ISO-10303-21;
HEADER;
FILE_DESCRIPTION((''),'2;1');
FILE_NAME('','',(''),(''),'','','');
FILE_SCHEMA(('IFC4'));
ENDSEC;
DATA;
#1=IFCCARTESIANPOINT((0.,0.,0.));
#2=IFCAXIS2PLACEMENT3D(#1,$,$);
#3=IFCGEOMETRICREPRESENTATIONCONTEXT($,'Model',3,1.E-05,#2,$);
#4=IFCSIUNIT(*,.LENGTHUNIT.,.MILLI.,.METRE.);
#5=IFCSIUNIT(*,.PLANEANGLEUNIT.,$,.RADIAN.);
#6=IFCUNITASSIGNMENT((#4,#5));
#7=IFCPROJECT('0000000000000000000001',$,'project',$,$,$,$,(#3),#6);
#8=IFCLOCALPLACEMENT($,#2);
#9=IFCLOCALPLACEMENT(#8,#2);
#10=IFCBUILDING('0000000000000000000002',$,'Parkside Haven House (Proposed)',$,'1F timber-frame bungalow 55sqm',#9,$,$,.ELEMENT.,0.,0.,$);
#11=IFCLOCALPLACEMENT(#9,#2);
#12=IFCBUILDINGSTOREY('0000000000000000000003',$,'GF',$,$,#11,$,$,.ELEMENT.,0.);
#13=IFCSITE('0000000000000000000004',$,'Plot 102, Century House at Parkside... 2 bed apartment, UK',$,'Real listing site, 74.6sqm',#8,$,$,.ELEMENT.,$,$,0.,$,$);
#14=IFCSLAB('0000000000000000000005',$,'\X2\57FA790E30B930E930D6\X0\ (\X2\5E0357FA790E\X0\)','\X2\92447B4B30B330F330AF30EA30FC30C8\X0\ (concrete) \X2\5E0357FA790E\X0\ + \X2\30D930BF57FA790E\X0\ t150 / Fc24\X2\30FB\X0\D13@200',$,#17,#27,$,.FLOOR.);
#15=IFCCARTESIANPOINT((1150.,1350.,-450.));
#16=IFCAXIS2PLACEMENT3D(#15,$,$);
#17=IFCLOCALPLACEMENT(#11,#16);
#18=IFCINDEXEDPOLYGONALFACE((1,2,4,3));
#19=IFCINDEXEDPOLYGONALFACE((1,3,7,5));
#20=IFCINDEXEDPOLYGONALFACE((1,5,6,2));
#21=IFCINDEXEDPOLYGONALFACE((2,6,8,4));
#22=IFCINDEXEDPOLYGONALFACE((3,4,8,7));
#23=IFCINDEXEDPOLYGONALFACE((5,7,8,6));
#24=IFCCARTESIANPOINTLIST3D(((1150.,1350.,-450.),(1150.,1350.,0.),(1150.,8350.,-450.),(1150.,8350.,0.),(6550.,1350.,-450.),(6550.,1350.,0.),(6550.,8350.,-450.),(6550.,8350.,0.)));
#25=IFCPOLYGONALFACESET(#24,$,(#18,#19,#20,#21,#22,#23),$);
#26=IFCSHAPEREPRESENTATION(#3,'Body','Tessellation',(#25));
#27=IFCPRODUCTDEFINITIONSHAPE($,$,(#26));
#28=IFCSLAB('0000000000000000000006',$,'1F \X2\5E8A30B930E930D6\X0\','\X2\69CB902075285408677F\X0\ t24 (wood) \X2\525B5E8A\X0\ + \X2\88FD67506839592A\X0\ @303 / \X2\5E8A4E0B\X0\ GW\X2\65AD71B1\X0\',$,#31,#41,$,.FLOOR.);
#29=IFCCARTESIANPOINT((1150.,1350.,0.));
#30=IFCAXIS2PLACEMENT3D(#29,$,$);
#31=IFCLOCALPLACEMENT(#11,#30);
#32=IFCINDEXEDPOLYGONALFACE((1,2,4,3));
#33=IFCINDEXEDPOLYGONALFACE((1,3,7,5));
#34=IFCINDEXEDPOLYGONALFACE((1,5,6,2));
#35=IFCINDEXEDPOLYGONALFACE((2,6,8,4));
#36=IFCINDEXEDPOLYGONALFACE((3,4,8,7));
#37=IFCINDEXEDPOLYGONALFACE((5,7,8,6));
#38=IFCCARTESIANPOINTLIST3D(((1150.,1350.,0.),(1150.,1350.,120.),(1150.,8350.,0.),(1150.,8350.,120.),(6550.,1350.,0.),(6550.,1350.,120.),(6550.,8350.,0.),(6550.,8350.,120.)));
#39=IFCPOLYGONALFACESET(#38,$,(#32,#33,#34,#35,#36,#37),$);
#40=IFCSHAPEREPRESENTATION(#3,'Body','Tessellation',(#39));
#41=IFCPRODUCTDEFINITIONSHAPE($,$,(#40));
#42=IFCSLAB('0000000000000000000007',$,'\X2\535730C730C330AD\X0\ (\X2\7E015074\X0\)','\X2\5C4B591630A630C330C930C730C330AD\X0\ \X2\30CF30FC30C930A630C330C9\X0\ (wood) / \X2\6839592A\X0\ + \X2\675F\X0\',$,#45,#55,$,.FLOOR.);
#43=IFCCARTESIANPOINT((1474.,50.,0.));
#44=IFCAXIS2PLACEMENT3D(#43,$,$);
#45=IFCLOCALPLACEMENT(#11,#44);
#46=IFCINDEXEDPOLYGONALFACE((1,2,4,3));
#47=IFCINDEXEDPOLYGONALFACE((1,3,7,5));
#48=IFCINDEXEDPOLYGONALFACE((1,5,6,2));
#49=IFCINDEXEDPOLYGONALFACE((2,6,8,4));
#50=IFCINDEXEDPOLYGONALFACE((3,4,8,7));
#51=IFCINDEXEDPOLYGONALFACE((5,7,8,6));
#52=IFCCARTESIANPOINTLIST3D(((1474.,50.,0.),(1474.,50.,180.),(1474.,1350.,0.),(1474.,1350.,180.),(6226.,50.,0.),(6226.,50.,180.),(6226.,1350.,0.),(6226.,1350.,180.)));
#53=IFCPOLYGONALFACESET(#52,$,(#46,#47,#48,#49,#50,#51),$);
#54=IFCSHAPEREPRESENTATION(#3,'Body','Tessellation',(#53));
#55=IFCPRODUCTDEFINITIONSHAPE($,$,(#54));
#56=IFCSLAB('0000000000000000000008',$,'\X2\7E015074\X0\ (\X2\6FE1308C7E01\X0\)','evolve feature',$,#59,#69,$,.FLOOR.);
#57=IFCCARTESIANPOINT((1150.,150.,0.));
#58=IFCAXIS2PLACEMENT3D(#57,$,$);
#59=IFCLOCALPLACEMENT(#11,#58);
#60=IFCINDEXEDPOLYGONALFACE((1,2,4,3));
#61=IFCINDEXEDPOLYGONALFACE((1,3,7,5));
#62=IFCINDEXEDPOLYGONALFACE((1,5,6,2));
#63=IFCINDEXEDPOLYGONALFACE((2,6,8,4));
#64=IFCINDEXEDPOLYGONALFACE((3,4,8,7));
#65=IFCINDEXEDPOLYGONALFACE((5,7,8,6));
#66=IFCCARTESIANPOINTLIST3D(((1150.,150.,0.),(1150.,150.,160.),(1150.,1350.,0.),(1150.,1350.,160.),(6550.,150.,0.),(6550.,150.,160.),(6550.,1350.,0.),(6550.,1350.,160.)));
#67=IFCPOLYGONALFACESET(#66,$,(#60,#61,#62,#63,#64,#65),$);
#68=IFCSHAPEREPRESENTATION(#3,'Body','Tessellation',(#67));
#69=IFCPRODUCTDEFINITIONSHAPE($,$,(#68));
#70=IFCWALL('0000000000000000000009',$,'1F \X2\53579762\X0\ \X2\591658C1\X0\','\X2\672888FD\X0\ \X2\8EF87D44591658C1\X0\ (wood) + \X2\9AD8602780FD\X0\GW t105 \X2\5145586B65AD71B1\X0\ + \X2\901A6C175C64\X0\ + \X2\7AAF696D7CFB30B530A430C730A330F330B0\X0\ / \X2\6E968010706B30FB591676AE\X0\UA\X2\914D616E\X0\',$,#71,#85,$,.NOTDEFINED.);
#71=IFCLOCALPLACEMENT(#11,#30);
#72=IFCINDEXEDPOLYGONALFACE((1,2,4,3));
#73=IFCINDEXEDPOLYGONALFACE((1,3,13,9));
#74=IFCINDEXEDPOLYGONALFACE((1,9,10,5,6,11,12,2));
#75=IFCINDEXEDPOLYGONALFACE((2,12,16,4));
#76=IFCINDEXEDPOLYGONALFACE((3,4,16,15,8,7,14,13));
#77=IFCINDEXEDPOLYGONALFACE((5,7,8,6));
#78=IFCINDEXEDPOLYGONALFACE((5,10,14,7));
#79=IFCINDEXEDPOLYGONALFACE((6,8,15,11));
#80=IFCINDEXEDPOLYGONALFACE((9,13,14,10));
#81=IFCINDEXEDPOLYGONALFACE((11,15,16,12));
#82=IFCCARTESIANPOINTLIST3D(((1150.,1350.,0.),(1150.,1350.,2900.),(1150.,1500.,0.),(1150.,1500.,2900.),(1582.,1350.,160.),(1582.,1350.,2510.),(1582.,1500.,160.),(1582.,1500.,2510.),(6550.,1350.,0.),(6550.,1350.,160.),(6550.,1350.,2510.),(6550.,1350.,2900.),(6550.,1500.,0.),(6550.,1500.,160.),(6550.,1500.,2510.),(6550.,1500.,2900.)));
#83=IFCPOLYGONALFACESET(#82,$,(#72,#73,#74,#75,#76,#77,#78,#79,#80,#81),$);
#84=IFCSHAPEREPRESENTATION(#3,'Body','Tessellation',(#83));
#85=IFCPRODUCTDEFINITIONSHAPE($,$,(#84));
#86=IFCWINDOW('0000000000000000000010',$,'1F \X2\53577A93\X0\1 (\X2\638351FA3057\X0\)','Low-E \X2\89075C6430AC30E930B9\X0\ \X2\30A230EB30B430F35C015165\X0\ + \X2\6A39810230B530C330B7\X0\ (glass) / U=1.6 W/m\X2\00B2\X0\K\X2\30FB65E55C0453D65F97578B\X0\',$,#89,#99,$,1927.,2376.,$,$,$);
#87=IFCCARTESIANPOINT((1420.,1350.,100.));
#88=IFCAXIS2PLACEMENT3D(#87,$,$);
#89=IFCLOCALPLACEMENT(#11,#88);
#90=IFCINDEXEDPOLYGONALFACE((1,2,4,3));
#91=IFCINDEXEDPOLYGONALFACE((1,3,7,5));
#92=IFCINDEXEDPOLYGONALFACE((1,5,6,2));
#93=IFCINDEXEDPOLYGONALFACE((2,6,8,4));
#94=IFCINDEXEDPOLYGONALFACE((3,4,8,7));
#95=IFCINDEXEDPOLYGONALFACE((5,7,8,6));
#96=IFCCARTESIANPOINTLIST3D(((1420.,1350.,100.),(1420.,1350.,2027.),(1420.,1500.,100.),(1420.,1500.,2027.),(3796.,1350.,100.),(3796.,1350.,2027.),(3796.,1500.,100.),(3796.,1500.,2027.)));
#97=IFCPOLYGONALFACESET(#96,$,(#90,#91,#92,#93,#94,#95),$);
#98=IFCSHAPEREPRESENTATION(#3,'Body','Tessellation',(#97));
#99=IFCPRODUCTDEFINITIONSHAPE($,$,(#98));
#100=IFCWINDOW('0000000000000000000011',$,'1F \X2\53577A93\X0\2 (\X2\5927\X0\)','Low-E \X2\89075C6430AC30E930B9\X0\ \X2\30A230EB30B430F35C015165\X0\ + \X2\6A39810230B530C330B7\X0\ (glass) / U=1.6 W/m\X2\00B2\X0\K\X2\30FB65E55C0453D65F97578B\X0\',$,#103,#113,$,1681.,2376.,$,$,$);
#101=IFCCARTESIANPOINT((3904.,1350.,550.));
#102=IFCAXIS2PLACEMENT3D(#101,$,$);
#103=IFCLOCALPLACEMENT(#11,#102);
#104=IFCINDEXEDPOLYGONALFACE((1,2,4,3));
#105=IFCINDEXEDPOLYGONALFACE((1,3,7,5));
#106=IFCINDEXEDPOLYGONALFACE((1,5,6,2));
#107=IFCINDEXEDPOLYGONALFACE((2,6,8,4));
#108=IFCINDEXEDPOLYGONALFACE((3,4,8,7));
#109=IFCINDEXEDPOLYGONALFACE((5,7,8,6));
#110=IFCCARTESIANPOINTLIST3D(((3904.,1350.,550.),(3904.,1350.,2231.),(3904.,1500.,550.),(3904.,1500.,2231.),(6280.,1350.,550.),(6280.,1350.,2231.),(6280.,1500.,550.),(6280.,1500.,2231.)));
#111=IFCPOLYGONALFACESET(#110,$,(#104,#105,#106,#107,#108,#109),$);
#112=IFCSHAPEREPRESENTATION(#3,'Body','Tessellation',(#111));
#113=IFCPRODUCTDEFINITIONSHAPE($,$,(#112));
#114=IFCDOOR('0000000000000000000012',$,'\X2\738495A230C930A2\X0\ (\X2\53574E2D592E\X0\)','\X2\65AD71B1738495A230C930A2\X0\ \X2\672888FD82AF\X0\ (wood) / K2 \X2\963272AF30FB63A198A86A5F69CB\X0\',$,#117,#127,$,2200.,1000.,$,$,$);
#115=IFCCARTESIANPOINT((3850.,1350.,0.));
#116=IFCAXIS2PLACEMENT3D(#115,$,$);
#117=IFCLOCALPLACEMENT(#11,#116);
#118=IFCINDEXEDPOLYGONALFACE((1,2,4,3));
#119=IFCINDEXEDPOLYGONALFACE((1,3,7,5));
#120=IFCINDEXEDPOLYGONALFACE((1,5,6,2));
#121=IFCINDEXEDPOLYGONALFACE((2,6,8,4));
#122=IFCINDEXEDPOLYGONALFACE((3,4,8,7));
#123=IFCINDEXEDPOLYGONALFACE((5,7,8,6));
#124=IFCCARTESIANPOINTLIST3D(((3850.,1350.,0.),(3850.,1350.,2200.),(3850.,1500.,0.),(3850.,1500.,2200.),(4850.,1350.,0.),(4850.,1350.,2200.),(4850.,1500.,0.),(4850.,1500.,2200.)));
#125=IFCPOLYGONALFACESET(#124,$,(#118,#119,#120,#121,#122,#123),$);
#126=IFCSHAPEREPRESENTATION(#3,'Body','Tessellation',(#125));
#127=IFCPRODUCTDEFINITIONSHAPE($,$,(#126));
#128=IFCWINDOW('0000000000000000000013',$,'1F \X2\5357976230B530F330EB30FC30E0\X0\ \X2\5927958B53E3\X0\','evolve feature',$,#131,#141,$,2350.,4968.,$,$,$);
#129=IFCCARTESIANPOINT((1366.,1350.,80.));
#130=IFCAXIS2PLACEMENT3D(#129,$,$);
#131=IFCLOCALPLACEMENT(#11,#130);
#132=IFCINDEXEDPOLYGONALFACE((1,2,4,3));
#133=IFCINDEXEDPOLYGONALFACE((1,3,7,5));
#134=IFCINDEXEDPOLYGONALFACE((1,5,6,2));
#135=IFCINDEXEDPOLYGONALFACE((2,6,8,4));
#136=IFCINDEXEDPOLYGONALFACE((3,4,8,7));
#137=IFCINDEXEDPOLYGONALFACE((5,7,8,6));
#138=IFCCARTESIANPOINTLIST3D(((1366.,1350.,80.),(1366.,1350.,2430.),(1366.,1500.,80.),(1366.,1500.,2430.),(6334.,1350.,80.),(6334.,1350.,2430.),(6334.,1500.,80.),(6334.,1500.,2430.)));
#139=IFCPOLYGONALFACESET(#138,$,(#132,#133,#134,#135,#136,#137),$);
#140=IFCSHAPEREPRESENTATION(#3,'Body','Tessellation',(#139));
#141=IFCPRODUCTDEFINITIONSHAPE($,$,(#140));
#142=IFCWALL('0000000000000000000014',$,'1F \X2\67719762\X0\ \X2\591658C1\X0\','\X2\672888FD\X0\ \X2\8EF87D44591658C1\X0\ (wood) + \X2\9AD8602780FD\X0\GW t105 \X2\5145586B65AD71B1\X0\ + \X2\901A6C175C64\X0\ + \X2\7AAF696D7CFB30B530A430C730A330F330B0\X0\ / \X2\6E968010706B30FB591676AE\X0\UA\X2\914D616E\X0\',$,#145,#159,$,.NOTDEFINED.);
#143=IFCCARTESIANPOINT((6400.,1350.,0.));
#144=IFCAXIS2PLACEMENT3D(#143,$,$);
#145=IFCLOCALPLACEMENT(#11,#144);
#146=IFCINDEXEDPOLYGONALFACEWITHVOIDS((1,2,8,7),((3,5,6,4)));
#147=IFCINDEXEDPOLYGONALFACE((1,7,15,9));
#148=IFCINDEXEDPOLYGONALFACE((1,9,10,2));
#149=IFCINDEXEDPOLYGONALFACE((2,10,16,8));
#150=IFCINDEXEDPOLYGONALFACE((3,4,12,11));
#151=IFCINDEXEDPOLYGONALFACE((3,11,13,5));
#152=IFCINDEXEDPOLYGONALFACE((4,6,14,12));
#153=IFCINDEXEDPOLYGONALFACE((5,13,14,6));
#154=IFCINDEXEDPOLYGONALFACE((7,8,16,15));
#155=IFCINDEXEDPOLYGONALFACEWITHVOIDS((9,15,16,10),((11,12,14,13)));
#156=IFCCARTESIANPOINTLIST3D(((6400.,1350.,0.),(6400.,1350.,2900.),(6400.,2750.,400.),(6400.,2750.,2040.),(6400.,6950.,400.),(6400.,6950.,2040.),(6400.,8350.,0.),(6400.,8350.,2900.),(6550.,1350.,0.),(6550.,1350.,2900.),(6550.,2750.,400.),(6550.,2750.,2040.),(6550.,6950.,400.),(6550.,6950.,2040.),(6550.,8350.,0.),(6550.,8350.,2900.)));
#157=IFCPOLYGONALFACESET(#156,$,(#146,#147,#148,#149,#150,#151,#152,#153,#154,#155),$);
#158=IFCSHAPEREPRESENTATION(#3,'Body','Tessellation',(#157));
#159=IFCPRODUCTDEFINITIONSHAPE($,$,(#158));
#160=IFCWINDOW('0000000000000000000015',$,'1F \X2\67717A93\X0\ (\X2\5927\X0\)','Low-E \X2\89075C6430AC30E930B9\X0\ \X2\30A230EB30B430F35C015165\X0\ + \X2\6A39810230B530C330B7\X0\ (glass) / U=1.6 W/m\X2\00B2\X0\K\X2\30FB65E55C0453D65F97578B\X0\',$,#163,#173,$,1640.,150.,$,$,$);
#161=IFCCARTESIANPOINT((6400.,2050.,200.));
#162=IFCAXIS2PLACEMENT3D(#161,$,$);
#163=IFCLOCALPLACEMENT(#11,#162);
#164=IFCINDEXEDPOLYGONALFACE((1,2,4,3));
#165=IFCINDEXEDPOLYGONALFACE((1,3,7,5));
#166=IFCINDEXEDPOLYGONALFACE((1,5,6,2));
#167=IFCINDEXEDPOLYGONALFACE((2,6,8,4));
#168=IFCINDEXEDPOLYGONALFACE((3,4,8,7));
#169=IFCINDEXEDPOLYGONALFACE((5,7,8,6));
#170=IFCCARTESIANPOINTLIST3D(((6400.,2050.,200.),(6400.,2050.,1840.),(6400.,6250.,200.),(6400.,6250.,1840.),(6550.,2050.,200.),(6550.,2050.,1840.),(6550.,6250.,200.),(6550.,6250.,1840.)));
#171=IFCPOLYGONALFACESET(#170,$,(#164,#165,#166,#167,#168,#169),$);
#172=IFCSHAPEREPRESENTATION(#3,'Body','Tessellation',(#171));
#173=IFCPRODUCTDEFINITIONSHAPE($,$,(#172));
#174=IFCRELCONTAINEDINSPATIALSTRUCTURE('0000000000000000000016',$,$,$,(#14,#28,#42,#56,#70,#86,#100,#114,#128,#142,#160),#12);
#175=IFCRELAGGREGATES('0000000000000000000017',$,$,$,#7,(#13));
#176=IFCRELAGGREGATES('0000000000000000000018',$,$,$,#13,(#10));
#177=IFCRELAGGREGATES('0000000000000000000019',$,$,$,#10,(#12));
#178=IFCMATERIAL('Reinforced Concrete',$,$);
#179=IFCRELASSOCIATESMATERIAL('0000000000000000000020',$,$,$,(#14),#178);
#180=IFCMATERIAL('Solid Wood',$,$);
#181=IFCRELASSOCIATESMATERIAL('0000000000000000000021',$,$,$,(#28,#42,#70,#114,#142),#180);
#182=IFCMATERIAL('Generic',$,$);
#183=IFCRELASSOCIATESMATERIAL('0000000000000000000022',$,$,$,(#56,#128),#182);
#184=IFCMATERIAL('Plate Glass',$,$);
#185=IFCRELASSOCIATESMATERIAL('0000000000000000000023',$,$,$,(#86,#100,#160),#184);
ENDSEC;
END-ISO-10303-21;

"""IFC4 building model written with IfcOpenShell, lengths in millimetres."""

from ifc_helpers import new_model, si_unit, frame, frame_2d, origin, place, context, project, spatial, rectangle, extrude, material, element, fill, save


model = new_model("IFC4")

# Units and contexts
model_context = context("Model", 3, precision=1e-05, world=origin())
ifc_project = project(units=[si_unit("LENGTHUNIT", "METRE", prefix="MILLI"), si_unit("PLANEANGLEUNIT", "RADIAN")], contexts=[model_context])

# Site, building, storey
site_placement = place(None, origin())
site = spatial("IfcSite", under=ifc_project, at=site_placement, Name="Plot 102, Century House at Parkside... 2 bed apartment, UK", ObjectType="Real listing site, 74.6sqm", CompositionType="ELEMENT", RefElevation=0.0)
building_placement = place(site_placement, origin())
building = spatial("IfcBuilding", under=site, at=building_placement, Name="Parkside Haven House (Proposed)", ObjectType="1F timber-frame bungalow 55sqm", CompositionType="ELEMENT", ElevationOfRefHeight=0.0, ElevationOfTerrain=0.0)
storey_placement = place(building_placement, origin())
storey = spatial("IfcBuildingStorey", under=building, at=storey_placement, Name="GF", CompositionType="ELEMENT", Elevation=0.0)

# Slabs
ifc_material_1 = material(Name="Reinforced Concrete")
slab_1_placement = place(storey_placement, frame((1150.0, 1350.0, -450.0)))
element("IfcSlab", 1, at=slab_1_placement, inside=storey, material=ifc_material_1, Name="基礎スラブ (布基礎)", Description="鉄筋コンクリート (concrete) 布基礎 + ベタ基礎 t150 / Fc24・D13@200", PredefinedType="FLOOR", context=model_context, shape_type="SweptSolid", body=[
    extrude(rectangle(XDim=5400.0, YDim=7000.0, at=frame_2d((2700.0, 3500.0))), frame((1150.0, 1350.0, -450.0)), (0.0, 0.0, 1.0), 450.0),
])
ifc_material_2 = material(Name="Solid Wood")
slab_2_placement = place(storey_placement, frame((1150.0, 1350.0, 0.0)))
element("IfcSlab", 2, at=slab_2_placement, inside=storey, material=ifc_material_2, Name="1F 床スラブ", Description="構造用合板 t24 (wood) 剛床 + 製材根太 @303 / 床下 GW断熱", PredefinedType="FLOOR", context=model_context, shape_type="SweptSolid", body=[
    extrude(rectangle(XDim=5400.0, YDim=7000.0, at=frame_2d((2700.0, 3500.0))), frame((1150.0, 1350.0, 0.0)), (0.0, 0.0, 1.0), 120.0),
])
slab_3_placement = place(storey_placement, frame((1474.0, 50.0, 0.0)))
element("IfcSlab", 3, at=slab_3_placement, inside=storey, material=ifc_material_2, Name="南デッキ (縁側)", Description="屋外ウッドデッキ ハードウッド (wood) / 根太 + 束", PredefinedType="FLOOR", context=model_context, shape_type="SweptSolid", body=[
    extrude(rectangle(XDim=4752.0, YDim=1300.0, at=frame_2d((2376.0, 650.0))), frame((1474.0, 50.0, 0.0)), (0.0, 0.0, 1.0), 180.0),
])
ifc_material_3 = material(Name="Generic")
slab_4_placement = place(storey_placement, frame((1150.0, 150.0, 0.0)))
element("IfcSlab", 4, at=slab_4_placement, inside=storey, material=ifc_material_3, Name="縁側 (濡れ縁)", Description="evolve feature", PredefinedType="FLOOR", context=model_context, shape_type="SweptSolid", body=[
    extrude(rectangle(XDim=5400.0, YDim=1200.0, at=frame_2d((2700.0, 600.0))), frame((1150.0, 150.0, 0.0)), (0.0, 0.0, 1.0), 160.0),
])

# Wall, openings, windows, door
wall_1_placement = place(storey_placement, frame((1150.0, 1350.0, 0.0)))
wall_1 = element("IfcWall", 5, at=wall_1_placement, inside=storey, material=ifc_material_2, Name="1F 南面 外壁", Description="木製 軸組外壁 (wood) + 高性能GW t105 充填断熱 + 通気層 + 窯業系サイディング / 準耐火・外皮UA配慮", PredefinedType="NOTDEFINED", context=model_context, shape_type="SweptSolid", body=[
    extrude(rectangle(XDim=5400.0, YDim=150.0, at=frame_2d((2700.0, 75.0))), frame((1150.0, 1350.0, 0.0)), (0.0, 0.0, 1.0), 2900.0),
])
opening_1_placement = place(storey_placement, frame((1420.0, 1350.0, 100.0)))
opening_1 = element("IfcOpeningElement", 6, at=opening_1_placement, cuts=wall_1, PredefinedType="NOTDEFINED", context=model_context, shape_type="SweptSolid", body=[
    extrude(rectangle(XDim=2376.0, YDim=150.0, at=frame_2d((1188.0, 75.0))), frame((1420.0, 1350.0, 100.0)), (0.0, 0.0, 1.0), 1927.0),
])
opening_2_placement = place(storey_placement, frame((3904.0, 1350.0, 550.0)))
opening_2 = element("IfcOpeningElement", 7, at=opening_2_placement, cuts=wall_1, PredefinedType="NOTDEFINED", context=model_context, shape_type="SweptSolid", body=[
    extrude(rectangle(XDim=2376.0, YDim=150.0, at=frame_2d((1188.0, 75.0))), frame((3904.0, 1350.0, 550.0)), (0.0, 0.0, 1.0), 1681.0),
])
opening_3_placement = place(storey_placement, frame((3850.0, 1350.0, 0.0)))
opening_3 = element("IfcOpeningElement", 8, at=opening_3_placement, cuts=wall_1, PredefinedType="NOTDEFINED", context=model_context, shape_type="SweptSolid", body=[
    extrude(rectangle(XDim=1000.0, YDim=150.0, at=frame_2d((500.0, 75.0))), frame((3850.0, 1350.0, 0.0)), (0.0, 0.0, 1.0), 2200.0),
])
opening_4_placement = place(storey_placement, frame((1366.0, 1350.0, 80.0)))
opening_4 = element("IfcOpeningElement", 9, at=opening_4_placement, cuts=wall_1, PredefinedType="NOTDEFINED", context=model_context, shape_type="SweptSolid", body=[
    extrude(rectangle(XDim=4968.0, YDim=150.0, at=frame_2d((2484.0, 75.0))), frame((1366.0, 1350.0, 80.0)), (0.0, 0.0, 1.0), 2350.0),
])
ifc_material_4 = material(Name="Plate Glass")
window_1_placement = place(storey_placement, frame((1420.0, 1350.0, 100.0)))
window_1 = element("IfcWindow", 10, at=window_1_placement, inside=storey, material=ifc_material_4, Name="1F 南窓1 (掃出し)", Description="Low-E 複層ガラス アルゴン封入 + 樹脂サッシ (glass) / U=1.6 W/m²K・日射取得型", OverallHeight=1927.0, OverallWidth=2376.0, context=model_context, shape_type="SweptSolid", body=[
    extrude(rectangle(XDim=2376.0, YDim=150.0, at=frame_2d((1188.0, 75.0))), frame((1420.0, 1350.0, 100.0)), (0.0, 0.0, 1.0), 1927.0),
])
fill(opening_1, window_1)
window_2_placement = place(storey_placement, frame((3904.0, 1350.0, 550.0)))
window_2 = element("IfcWindow", 11, at=window_2_placement, inside=storey, material=ifc_material_4, Name="1F 南窓2 (大)", Description="Low-E 複層ガラス アルゴン封入 + 樹脂サッシ (glass) / U=1.6 W/m²K・日射取得型", OverallHeight=1681.0, OverallWidth=2376.0, context=model_context, shape_type="SweptSolid", body=[
    extrude(rectangle(XDim=2376.0, YDim=150.0, at=frame_2d((1188.0, 75.0))), frame((3904.0, 1350.0, 550.0)), (0.0, 0.0, 1.0), 1681.0),
])
fill(opening_2, window_2)
door_placement = place(storey_placement, frame((3850.0, 1350.0, 0.0)))
door = element("IfcDoor", 12, at=door_placement, inside=storey, material=ifc_material_2, Name="玄関ドア (南中央)", Description="断熱玄関ドア 木製芯 (wood) / K2 防犯・採風機構", OverallHeight=2200.0, OverallWidth=1000.0, context=model_context, shape_type="SweptSolid", body=[
    extrude(rectangle(XDim=1000.0, YDim=150.0, at=frame_2d((500.0, 75.0))), frame((3850.0, 1350.0, 0.0)), (0.0, 0.0, 1.0), 2200.0),
])
fill(opening_3, door)
window_3_placement = place(storey_placement, frame((1366.0, 1350.0, 80.0)))
window_3 = element("IfcWindow", 13, at=window_3_placement, inside=storey, material=ifc_material_3, Name="1F 南面サンルーム 大開口", Description="evolve feature", OverallHeight=2350.0, OverallWidth=4968.0, context=model_context, shape_type="SweptSolid", body=[
    extrude(rectangle(XDim=4968.0, YDim=150.0, at=frame_2d((2484.0, 75.0))), frame((1366.0, 1350.0, 80.0)), (0.0, 0.0, 1.0), 2350.0),
])
fill(opening_4, window_3)

# Wall, opening, window
wall_2_placement = place(storey_placement, frame((6400.0, 1350.0, 0.0)))
wall_2 = element("IfcWall", 14, at=wall_2_placement, inside=storey, material=ifc_material_2, Name="1F 東面 外壁", Description="木製 軸組外壁 (wood) + 高性能GW t105 充填断熱 + 通気層 + 窯業系サイディング / 準耐火・外皮UA配慮", PredefinedType="NOTDEFINED", context=model_context, shape_type="SweptSolid", body=[
    extrude(rectangle(XDim=150.0, YDim=7000.0, at=frame_2d((75.0, 3500.0))), frame((6400.0, 1350.0, 0.0)), (0.0, 0.0, 1.0), 2900.0),
])
opening_5_placement = place(storey_placement, frame((6400.0, 2050.0, 200.0)))
opening_5 = element("IfcOpeningElement", 15, at=opening_5_placement, cuts=wall_2, PredefinedType="NOTDEFINED", context=model_context, shape_type="SweptSolid", body=[
    extrude(rectangle(XDim=150.0, YDim=4200.0, at=frame_2d((75.0, 2100.0))), frame((6400.0, 2050.0, 200.0)), (0.0, 0.0, 1.0), 1640.0),
])
window_4_placement = place(storey_placement, frame((6400.0, 2050.0, 200.0)))
window_4 = element("IfcWindow", 16, at=window_4_placement, inside=storey, material=ifc_material_4, Name="1F 東窓 (大)", Description="Low-E 複層ガラス アルゴン封入 + 樹脂サッシ (glass) / U=1.6 W/m²K・日射取得型", OverallHeight=1640.0, OverallWidth=150.0, context=model_context, shape_type="SweptSolid", body=[
    extrude(rectangle(XDim=150.0, YDim=4200.0, at=frame_2d((75.0, 2100.0))), frame((6400.0, 2050.0, 200.0)), (0.0, 0.0, 1.0), 1640.0),
])
fill(opening_5, window_4)

save(model, "model.ifc")
